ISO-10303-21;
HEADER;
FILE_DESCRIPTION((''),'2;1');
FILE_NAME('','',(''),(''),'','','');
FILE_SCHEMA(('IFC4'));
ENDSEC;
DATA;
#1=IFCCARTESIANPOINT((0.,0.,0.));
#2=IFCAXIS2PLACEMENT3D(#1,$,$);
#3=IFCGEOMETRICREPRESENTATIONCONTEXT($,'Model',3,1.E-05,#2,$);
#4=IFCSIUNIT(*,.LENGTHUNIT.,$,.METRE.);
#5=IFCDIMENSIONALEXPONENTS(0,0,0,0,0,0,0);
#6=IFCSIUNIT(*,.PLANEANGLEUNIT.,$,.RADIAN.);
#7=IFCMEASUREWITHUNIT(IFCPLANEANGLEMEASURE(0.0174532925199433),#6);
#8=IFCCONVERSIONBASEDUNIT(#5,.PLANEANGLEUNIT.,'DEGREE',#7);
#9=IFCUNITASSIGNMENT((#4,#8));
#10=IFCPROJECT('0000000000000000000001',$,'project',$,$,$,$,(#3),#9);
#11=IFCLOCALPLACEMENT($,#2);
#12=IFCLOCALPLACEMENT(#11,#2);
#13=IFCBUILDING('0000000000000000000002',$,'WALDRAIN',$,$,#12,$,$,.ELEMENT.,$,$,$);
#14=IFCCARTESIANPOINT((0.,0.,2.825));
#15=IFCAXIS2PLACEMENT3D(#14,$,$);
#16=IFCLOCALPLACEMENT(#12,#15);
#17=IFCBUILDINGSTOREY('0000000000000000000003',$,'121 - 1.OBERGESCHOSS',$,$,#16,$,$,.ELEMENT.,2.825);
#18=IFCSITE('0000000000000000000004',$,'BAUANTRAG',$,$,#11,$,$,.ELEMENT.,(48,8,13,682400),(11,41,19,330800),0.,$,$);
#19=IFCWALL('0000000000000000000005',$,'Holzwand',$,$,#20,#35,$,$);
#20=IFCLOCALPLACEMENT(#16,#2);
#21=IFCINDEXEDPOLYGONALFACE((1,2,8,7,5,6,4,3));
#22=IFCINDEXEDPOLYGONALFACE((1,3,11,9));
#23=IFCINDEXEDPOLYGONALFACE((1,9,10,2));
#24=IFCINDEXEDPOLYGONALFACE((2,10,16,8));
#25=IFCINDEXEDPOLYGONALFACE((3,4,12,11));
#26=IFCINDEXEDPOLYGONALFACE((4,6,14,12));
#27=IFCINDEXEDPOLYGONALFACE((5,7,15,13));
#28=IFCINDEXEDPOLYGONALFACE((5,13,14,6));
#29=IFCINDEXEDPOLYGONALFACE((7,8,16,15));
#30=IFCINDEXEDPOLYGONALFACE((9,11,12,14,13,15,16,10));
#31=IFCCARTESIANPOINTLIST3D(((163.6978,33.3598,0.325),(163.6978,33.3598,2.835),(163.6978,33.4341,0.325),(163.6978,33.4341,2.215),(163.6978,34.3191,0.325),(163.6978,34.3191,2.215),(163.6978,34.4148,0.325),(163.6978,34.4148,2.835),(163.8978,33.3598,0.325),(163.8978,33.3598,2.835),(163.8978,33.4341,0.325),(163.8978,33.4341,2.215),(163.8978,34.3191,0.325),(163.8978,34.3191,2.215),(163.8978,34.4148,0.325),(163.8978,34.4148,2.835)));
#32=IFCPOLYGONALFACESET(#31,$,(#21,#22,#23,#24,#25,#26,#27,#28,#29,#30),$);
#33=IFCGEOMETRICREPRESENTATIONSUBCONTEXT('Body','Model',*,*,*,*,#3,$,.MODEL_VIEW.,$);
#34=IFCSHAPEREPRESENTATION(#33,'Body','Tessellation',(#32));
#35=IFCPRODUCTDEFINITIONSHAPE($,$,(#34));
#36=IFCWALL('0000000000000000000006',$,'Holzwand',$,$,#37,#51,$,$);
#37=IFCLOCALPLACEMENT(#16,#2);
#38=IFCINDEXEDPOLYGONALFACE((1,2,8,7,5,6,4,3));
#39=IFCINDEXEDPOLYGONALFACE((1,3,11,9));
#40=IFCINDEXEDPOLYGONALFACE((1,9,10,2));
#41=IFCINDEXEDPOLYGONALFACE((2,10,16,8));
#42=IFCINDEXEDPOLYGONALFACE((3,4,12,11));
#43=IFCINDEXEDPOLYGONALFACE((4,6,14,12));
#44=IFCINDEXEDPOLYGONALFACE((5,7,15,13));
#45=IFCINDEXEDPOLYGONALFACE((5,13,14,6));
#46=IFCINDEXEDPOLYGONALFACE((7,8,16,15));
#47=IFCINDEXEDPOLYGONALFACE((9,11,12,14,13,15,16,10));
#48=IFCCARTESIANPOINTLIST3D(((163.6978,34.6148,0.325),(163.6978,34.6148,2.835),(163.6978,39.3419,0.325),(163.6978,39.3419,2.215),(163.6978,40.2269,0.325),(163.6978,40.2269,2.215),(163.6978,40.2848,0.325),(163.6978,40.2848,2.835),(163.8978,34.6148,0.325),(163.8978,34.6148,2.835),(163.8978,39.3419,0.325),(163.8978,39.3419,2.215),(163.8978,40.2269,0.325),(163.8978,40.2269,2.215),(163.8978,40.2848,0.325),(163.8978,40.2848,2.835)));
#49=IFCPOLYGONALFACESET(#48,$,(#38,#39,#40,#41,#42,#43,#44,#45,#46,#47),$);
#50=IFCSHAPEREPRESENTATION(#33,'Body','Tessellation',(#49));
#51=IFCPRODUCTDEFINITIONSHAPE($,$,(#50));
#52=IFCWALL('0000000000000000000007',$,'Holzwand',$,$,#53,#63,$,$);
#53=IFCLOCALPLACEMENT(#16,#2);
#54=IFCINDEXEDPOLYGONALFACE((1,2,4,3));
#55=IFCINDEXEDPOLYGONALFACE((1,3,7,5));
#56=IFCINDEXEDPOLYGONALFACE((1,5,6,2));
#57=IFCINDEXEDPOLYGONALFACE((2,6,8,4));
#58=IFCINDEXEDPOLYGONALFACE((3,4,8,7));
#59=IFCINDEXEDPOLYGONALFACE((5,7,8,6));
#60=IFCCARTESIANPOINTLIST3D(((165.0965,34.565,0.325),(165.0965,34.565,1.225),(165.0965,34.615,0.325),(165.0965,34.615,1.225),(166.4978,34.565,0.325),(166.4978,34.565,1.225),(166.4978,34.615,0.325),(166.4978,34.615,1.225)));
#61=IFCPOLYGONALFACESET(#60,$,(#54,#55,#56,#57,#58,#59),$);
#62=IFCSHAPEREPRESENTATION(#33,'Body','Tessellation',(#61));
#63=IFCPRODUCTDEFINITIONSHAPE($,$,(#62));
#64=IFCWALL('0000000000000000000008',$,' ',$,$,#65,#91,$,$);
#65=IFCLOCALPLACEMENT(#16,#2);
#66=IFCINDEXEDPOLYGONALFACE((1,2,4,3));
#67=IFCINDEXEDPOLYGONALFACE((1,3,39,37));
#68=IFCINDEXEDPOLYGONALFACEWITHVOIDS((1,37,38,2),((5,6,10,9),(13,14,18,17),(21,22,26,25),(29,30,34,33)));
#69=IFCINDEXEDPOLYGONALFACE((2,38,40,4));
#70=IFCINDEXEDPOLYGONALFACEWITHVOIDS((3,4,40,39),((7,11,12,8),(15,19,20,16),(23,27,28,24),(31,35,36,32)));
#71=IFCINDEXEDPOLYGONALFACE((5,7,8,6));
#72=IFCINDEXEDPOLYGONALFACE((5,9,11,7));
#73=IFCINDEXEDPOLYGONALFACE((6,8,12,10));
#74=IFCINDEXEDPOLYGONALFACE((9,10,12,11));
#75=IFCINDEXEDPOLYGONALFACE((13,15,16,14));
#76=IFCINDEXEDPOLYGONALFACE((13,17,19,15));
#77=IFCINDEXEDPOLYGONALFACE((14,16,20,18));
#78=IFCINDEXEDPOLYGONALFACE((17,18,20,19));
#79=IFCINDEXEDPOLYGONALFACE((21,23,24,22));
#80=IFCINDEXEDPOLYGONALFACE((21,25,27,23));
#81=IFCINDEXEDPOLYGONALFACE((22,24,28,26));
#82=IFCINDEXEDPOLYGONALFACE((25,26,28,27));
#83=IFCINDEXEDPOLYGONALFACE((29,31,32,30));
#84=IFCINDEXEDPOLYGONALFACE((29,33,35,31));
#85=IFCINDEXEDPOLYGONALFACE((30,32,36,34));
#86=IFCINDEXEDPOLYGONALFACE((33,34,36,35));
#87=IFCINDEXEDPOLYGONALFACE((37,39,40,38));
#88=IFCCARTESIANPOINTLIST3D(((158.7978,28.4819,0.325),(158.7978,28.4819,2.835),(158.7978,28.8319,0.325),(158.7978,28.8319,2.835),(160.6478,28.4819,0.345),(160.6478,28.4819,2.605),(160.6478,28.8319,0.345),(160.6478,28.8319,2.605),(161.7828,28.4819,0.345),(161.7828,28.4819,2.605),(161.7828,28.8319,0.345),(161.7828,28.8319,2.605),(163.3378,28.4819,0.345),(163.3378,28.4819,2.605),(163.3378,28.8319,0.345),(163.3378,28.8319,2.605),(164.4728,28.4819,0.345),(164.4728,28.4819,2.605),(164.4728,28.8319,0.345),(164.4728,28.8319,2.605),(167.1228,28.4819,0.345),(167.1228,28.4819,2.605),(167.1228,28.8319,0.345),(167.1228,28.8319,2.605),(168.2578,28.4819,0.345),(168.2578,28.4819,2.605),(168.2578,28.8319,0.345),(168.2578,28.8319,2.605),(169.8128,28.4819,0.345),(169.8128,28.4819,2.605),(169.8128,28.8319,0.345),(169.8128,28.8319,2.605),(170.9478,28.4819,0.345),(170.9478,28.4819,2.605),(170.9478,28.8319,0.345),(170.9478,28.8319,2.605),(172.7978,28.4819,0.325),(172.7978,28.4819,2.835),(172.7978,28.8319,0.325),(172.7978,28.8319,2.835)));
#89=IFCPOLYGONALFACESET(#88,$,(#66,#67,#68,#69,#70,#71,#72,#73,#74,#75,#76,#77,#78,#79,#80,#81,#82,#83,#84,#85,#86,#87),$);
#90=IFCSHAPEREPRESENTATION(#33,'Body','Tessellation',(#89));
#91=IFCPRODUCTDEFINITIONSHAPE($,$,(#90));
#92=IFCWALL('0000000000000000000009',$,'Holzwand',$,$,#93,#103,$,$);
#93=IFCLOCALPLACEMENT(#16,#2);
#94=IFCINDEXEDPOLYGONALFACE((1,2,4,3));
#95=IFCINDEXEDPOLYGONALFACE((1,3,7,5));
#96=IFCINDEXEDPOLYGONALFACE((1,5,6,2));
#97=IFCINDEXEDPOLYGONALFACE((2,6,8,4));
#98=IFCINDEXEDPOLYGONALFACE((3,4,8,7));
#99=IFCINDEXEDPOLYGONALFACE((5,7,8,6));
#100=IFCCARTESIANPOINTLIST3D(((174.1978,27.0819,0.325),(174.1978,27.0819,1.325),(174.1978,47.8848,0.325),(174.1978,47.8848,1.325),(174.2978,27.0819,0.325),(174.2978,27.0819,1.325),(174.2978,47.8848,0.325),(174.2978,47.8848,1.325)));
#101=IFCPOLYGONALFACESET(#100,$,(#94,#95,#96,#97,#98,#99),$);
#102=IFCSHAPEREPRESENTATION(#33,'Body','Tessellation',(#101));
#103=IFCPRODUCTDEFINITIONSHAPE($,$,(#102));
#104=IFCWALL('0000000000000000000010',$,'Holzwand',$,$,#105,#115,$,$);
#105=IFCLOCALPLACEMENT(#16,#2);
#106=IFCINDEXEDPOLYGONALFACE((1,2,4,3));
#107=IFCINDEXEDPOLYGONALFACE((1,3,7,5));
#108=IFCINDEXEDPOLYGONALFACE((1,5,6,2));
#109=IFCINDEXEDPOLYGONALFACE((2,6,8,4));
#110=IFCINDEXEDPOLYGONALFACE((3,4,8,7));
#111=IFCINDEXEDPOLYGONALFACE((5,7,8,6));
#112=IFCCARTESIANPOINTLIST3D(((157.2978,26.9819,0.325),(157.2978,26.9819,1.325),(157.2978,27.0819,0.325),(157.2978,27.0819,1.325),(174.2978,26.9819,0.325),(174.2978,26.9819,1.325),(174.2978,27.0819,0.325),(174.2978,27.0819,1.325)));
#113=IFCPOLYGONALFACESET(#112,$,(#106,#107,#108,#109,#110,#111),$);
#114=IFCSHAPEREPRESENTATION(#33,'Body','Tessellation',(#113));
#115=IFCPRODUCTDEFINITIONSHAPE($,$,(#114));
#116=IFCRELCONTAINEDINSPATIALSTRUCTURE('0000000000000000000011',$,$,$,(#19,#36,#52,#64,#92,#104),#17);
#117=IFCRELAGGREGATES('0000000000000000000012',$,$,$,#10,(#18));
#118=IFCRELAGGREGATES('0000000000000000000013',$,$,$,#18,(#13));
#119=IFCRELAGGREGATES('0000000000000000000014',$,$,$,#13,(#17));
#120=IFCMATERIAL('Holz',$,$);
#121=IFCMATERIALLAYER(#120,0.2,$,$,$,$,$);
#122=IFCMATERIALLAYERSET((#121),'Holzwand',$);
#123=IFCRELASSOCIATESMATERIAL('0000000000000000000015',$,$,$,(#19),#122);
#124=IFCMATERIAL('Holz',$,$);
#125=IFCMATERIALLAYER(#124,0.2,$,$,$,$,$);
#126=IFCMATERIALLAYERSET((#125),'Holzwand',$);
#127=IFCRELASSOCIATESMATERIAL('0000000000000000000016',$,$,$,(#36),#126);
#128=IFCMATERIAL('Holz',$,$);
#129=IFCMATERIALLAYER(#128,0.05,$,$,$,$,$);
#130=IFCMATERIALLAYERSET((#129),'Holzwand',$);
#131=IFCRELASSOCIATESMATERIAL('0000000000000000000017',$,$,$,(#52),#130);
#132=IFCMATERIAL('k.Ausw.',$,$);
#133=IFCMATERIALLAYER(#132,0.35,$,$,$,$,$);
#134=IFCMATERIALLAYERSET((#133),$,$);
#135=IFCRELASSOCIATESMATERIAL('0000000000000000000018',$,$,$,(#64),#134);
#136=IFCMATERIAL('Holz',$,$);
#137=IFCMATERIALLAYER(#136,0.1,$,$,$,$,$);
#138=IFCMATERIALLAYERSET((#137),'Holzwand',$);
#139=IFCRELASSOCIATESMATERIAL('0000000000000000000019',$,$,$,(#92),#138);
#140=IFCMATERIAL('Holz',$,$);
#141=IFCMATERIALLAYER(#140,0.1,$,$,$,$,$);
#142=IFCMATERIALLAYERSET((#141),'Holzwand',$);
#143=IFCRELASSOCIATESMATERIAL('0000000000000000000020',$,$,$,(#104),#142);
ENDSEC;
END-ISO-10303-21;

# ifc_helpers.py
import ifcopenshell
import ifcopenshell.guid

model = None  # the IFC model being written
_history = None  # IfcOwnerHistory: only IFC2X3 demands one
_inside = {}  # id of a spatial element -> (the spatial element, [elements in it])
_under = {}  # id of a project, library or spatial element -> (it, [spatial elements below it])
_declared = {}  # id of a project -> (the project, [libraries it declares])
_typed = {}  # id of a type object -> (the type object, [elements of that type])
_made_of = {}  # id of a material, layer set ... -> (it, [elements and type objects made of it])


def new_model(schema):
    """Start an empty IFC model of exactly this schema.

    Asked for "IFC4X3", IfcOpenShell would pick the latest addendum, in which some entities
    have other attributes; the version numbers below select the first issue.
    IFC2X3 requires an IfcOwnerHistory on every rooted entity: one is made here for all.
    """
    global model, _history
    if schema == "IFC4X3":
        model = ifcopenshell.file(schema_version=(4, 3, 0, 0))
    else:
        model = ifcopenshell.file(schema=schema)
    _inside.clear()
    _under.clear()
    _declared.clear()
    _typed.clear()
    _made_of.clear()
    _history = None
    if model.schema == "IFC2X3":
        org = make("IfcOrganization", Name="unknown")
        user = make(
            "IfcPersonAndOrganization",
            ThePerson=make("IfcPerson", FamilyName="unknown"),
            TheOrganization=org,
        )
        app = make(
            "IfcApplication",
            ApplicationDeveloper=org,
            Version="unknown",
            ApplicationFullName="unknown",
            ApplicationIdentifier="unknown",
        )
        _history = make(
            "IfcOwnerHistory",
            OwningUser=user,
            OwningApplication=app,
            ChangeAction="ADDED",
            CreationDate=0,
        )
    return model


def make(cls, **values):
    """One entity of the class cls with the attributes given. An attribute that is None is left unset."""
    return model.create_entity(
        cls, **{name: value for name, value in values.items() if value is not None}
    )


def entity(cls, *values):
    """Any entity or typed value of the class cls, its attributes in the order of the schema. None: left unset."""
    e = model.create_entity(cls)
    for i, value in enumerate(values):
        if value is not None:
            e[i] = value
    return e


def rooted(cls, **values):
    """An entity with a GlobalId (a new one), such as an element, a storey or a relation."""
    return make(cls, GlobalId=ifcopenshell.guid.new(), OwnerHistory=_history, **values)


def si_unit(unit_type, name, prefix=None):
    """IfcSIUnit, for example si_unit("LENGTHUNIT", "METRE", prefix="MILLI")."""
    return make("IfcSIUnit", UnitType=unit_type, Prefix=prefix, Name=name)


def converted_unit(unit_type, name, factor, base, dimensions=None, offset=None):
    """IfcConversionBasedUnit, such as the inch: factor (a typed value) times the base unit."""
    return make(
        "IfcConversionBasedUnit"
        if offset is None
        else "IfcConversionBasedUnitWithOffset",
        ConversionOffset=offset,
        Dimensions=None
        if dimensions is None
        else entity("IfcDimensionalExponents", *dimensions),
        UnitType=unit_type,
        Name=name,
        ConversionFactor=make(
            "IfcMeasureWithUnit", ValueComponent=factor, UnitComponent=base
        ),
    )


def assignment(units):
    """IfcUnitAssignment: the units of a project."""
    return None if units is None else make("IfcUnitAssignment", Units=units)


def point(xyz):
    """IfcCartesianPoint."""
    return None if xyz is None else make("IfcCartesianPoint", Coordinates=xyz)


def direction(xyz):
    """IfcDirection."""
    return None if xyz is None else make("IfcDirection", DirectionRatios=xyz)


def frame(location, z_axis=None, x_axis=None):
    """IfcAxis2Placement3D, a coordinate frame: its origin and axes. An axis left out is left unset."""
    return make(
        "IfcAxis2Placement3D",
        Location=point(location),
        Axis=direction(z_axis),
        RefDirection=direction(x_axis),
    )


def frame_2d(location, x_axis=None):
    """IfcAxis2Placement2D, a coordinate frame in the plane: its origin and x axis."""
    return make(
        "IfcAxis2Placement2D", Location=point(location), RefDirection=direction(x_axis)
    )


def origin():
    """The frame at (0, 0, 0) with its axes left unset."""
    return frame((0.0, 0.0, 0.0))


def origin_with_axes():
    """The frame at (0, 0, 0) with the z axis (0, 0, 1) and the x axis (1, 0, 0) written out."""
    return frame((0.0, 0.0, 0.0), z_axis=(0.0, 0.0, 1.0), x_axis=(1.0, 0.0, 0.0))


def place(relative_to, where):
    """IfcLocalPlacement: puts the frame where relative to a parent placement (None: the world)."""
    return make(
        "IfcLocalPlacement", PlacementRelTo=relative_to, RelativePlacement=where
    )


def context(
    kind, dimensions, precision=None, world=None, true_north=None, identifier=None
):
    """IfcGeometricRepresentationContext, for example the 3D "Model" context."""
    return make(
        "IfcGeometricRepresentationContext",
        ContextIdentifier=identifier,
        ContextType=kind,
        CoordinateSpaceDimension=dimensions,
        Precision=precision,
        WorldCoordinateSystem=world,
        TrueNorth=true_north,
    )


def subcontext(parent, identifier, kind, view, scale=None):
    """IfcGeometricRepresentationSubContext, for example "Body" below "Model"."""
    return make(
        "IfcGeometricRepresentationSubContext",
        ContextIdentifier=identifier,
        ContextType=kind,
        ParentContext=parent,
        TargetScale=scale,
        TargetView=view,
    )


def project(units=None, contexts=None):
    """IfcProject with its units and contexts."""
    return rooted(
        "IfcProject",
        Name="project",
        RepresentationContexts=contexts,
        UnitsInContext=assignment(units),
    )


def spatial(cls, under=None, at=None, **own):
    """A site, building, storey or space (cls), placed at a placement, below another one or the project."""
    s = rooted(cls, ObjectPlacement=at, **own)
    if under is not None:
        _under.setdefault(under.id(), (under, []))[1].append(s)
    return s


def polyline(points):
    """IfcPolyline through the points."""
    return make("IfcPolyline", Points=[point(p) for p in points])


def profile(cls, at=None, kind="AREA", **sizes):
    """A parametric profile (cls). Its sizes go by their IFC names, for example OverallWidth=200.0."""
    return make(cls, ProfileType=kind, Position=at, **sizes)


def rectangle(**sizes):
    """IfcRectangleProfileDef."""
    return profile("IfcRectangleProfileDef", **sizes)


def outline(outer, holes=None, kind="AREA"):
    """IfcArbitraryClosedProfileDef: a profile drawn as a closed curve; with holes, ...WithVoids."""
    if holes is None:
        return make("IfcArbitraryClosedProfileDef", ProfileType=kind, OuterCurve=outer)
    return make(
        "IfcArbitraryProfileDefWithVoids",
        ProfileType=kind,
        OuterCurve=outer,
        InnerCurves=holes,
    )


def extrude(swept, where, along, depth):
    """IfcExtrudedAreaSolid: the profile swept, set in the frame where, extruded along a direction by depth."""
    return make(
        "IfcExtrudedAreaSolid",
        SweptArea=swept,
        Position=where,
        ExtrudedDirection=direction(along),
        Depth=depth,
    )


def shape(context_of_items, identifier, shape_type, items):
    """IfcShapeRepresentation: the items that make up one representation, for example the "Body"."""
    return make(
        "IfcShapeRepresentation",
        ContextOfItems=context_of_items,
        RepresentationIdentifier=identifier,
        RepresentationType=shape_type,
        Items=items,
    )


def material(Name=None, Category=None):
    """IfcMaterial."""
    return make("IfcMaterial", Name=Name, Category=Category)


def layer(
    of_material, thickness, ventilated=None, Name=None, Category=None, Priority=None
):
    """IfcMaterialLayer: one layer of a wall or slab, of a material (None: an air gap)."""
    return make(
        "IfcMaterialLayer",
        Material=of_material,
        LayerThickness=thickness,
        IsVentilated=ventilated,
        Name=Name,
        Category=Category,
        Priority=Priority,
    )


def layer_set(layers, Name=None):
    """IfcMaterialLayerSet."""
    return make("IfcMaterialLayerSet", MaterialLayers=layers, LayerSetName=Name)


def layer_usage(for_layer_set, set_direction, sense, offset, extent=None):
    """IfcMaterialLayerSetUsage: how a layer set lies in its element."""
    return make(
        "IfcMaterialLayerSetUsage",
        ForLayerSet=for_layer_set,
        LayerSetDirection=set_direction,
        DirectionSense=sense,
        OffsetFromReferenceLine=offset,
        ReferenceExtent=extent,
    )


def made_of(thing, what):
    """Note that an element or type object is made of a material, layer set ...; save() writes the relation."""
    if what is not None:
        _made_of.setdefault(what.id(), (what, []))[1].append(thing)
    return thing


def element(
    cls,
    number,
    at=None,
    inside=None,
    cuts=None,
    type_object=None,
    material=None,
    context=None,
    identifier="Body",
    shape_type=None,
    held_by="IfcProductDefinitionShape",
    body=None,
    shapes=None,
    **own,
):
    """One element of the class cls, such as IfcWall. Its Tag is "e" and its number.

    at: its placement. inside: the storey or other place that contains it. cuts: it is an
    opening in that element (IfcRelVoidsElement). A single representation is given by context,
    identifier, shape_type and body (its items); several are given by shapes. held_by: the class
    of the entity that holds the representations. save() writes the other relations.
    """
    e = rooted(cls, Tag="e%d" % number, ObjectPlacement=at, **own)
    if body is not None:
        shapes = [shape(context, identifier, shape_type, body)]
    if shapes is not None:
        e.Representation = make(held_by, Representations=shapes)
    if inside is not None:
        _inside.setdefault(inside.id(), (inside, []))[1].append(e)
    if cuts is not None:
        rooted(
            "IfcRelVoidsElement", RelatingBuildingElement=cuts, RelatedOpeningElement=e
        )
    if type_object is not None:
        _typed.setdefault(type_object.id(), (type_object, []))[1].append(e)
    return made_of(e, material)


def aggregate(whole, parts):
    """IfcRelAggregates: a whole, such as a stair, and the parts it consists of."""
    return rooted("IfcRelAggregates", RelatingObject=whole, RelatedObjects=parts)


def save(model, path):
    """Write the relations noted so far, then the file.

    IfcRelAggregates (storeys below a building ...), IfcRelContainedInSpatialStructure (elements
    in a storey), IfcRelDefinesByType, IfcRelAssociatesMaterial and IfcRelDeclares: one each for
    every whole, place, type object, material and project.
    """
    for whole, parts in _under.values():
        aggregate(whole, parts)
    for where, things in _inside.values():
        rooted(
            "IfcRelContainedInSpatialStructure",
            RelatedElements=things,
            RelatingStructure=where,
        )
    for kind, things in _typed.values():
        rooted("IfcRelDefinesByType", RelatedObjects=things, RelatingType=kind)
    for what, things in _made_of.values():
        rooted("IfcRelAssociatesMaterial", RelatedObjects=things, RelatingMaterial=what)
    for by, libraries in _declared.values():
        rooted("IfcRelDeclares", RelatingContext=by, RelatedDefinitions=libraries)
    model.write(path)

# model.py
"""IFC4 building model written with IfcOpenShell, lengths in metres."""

from ifc_helpers import new_model, entity, si_unit, converted_unit, frame, frame_2d, origin, origin_with_axes, place, context, subcontext, project, spatial, polyline, rectangle, outline, extrude, material, layer, layer_set, layer_usage, element, save


model = new_model("IFC4")

# Units and contexts
model_context = context("Model", 3, precision=1e-05, world=origin())
body_context = subcontext(model_context, "Body", "Model", "MODEL_VIEW")
ifc_project = project(units=[si_unit("LENGTHUNIT", "METRE"), converted_unit("PLANEANGLEUNIT", "DEGREE", entity("IfcPlaneAngleMeasure", 0.0174532925199433), si_unit("PLANEANGLEUNIT", "RADIAN"), dimensions=[0, 0, 0, 0, 0, 0, 0])], contexts=[model_context])

# Site, building, storey
site_placement = place(None, origin())
site = spatial("IfcSite", under=ifc_project, at=site_placement, Name="BAUANTRAG", CompositionType="ELEMENT", RefLatitude=(48, 8, 13, 682400), RefLongitude=(11, 41, 19, 330800), RefElevation=0.0)
building_placement = place(site_placement, origin())
building = spatial("IfcBuilding", under=site, at=building_placement, Name="WALDRAIN", CompositionType="ELEMENT")
storey_placement = place(building_placement, frame((0.0, 0.0, 2.825)))
storey = spatial("IfcBuildingStorey", under=building, at=storey_placement, Name="121 - 1.OBERGESCHOSS", CompositionType="ELEMENT", Elevation=2.825)

# Walls, openings
ifc_material_1 = material(Name="Holz")
ifc_layer_1 = layer(ifc_material_1, 0.2)
ifc_layer_set_1 = layer_set([ifc_layer_1], Name="Holzwand")
ifc_layer_usage_1 = layer_usage(ifc_layer_set_1, "AXIS2", "POSITIVE", 0.0)
wall_1_placement = place(storey_placement, frame((163.6978, 34.4148, 0.325), z_axis=(0.0, 0.0, 1.0), x_axis=(0.0, -1.0, 0.0)))
wall_1 = element("IfcWall", 1, at=wall_1_placement, inside=storey, material=ifc_layer_usage_1, Name="Holzwand", context=body_context, shape_type="SweptSolid", body=[
    extrude(rectangle(XDim=1.055, YDim=0.2, at=frame_2d((0.5275, 0.1), x_axis=(1.0, 0.0))), origin_with_axes(), (0.0, 0.0, 1.0), 2.51),
])
opening_1_placement = place(wall_1_placement, frame((0.9807, 0.2, -0.12), z_axis=(0.0, -1.0, 0.0), x_axis=(0.0, 0.0, 1.0)))
element("IfcOpeningElement", 2, at=opening_1_placement, cuts=wall_1, ObjectType="Opening", context=body_context, shape_type="SweptSolid", body=[
    extrude(outline(polyline([(0.0, 0.885), (2.01, 0.885), (2.01, 0.0), (0.0, 0.0), (0.0, 0.885)])), origin_with_axes(), (0.0, 0.0, 1.0), 0.2),
])
ifc_material_2 = material(Name="Holz")
ifc_layer_2 = layer(ifc_material_2, 0.2)
ifc_layer_set_2 = layer_set([ifc_layer_2], Name="Holzwand")
ifc_layer_usage_2 = layer_usage(ifc_layer_set_2, "AXIS2", "POSITIVE", 0.0)
wall_2_placement = place(storey_placement, frame((163.8978, 34.6148, 0.325), z_axis=(0.0, 0.0, 1.0), x_axis=(0.0, 1.0, 0.0)))
wall_2 = element("IfcWall", 3, at=wall_2_placement, inside=storey, material=ifc_layer_usage_2, Name="Holzwand", context=body_context, shape_type="SweptSolid", body=[
    extrude(rectangle(XDim=5.67, YDim=0.2, at=frame_2d((2.835, 0.1), x_axis=(1.0, 0.0))), origin_with_axes(), (0.0, 0.0, 1.0), 2.51),
])
opening_2_placement = place(wall_2_placement, frame((4.7271, 0.0, -0.12), z_axis=(0.0, 1.0, 0.0), x_axis=(0.0, 0.0, 1.0)))
element("IfcOpeningElement", 4, at=opening_2_placement, cuts=wall_2, ObjectType="Opening", context=body_context, shape_type="SweptSolid", body=[
    extrude(outline(polyline([(0.0, 0.885), (2.01, 0.885), (2.01, 0.0), (0.0, 0.0), (0.0, 0.885)])), origin_with_axes(), (0.0, 0.0, 1.0), 0.2),
])

# Wall
ifc_material_3 = material(Name="Holz")
ifc_layer_3 = layer(ifc_material_3, 0.05)
ifc_layer_set_3 = layer_set([ifc_layer_3], Name="Holzwand")
ifc_layer_usage_3 = layer_usage(ifc_layer_set_3, "AXIS2", "POSITIVE", 0.0)
wall_3_placement = place(storey_placement, frame((166.4978, 34.615, 0.325), z_axis=(0.0, 0.0, 1.0), x_axis=(-1.0, 0.0, 0.0)))
element("IfcWall", 5, at=wall_3_placement, inside=storey, material=ifc_layer_usage_3, Name="Holzwand", context=body_context, shape_type="SweptSolid", body=[
    extrude(rectangle(XDim=1.4012, YDim=0.05, at=frame_2d((0.7006, 0.025), x_axis=(1.0, 0.0))), origin_with_axes(), (0.0, 0.0, 1.0), 0.9),
])

# Wall, openings
ifc_material_4 = material(Name="k.Ausw.")
ifc_layer_4 = layer(ifc_material_4, 0.35)
ifc_layer_set_4 = layer_set([ifc_layer_4])
ifc_layer_usage_4 = layer_usage(ifc_layer_set_4, "AXIS2", "POSITIVE", 0.0)
wall_4_placement = place(storey_placement, frame((158.7978, 28.4819, 0.325)))
wall_4 = element("IfcWall", 6, at=wall_4_placement, inside=storey, material=ifc_layer_usage_4, Name=" ", context=body_context, shape_type="SweptSolid", body=[
    extrude(rectangle(XDim=14.0, YDim=0.35, at=frame_2d((7.0, 0.175), x_axis=(1.0, 0.0))), origin_with_axes(), (0.0, 0.0, 1.0), 2.51),
])
opening_3_placement = place(wall_4_placement, frame((2.985, 0.35, 0.02), z_axis=(0.0, -1.0, 0.0), x_axis=(0.0, 0.0, 1.0)))
element("IfcOpeningElement", 7, at=opening_3_placement, cuts=wall_4, ObjectType="Opening", context=body_context, shape_type="SweptSolid", body=[
    extrude(outline(polyline([(0.0, 1.135), (2.26, 1.135), (2.26, 0.0), (0.0, 0.0), (0.0, 1.135)])), origin_with_axes(), (0.0, 0.0, 1.0), 0.35),
])
opening_4_placement = place(wall_4_placement, frame((5.675, 0.35, 0.02), z_axis=(0.0, -1.0, 0.0), x_axis=(0.0, 0.0, 1.0)))
element("IfcOpeningElement", 8, at=opening_4_placement, cuts=wall_4, ObjectType="Opening", context=body_context, shape_type="SweptSolid", body=[
    extrude(outline(polyline([(0.0, 1.135), (2.26, 1.135), (2.26, 0.0), (0.0, 0.0), (0.0, 1.135)])), origin_with_axes(), (0.0, 0.0, 1.0), 0.35),
])
opening_5_placement = place(wall_4_placement, frame((9.46, 0.35, 0.02), z_axis=(0.0, -1.0, 0.0), x_axis=(0.0, 0.0, 1.0)))
element("IfcOpeningElement", 9, at=opening_5_placement, cuts=wall_4, ObjectType="Opening", context=body_context, shape_type="SweptSolid", body=[
    extrude(outline(polyline([(0.0, 1.135), (2.26, 1.135), (2.26, 0.0), (0.0, 0.0), (0.0, 1.135)])), origin_with_axes(), (0.0, 0.0, 1.0), 0.35),
])
opening_6_placement = place(wall_4_placement, frame((12.15, 0.35, 0.02), z_axis=(0.0, -1.0, 0.0), x_axis=(0.0, 0.0, 1.0)))
element("IfcOpeningElement", 10, at=opening_6_placement, cuts=wall_4, ObjectType="Opening", context=body_context, shape_type="SweptSolid", body=[
    extrude(outline(polyline([(0.0, 1.135), (2.26, 1.135), (2.26, 0.0), (0.0, 0.0), (0.0, 1.135)])), origin_with_axes(), (0.0, 0.0, 1.0), 0.35),
])

# Walls
ifc_material_5 = material(Name="Holz")
ifc_layer_5 = layer(ifc_material_5, 0.1)
ifc_layer_set_5 = layer_set([ifc_layer_5], Name="Holzwand")
ifc_layer_usage_5 = layer_usage(ifc_layer_set_5, "AXIS2", "POSITIVE", 0.0)
wall_5_placement = place(storey_placement, frame((174.2978, 27.0819, 0.325), z_axis=(0.0, 0.0, 1.0), x_axis=(0.0, 1.0, 0.0)))
element("IfcWall", 11, at=wall_5_placement, inside=storey, material=ifc_layer_usage_5, Name="Holzwand", context=body_context, shape_type="SweptSolid", body=[
    extrude(rectangle(XDim=20.8029, YDim=0.1, at=frame_2d((10.4014, 0.05), x_axis=(1.0, 0.0))), origin_with_axes(), (0.0, 0.0, 1.0), 1.0),
])
ifc_material_6 = material(Name="Holz")
ifc_layer_6 = layer(ifc_material_6, 0.1)
ifc_layer_set_6 = layer_set([ifc_layer_6], Name="Holzwand")
ifc_layer_usage_6 = layer_usage(ifc_layer_set_6, "AXIS2", "POSITIVE", 0.0)
wall_6_placement = place(storey_placement, frame((157.2978, 26.9819, 0.325)))
element("IfcWall", 12, at=wall_6_placement, inside=storey, material=ifc_layer_usage_6, Name="Holzwand", context=body_context, shape_type="SweptSolid", body=[
    extrude(rectangle(XDim=17.0, YDim=0.1, at=frame_2d((8.5, 0.05), x_axis=(1.0, 0.0))), origin_with_axes(), (0.0, 0.0, 1.0), 1.0),
])

save(model, "model.ifc")
